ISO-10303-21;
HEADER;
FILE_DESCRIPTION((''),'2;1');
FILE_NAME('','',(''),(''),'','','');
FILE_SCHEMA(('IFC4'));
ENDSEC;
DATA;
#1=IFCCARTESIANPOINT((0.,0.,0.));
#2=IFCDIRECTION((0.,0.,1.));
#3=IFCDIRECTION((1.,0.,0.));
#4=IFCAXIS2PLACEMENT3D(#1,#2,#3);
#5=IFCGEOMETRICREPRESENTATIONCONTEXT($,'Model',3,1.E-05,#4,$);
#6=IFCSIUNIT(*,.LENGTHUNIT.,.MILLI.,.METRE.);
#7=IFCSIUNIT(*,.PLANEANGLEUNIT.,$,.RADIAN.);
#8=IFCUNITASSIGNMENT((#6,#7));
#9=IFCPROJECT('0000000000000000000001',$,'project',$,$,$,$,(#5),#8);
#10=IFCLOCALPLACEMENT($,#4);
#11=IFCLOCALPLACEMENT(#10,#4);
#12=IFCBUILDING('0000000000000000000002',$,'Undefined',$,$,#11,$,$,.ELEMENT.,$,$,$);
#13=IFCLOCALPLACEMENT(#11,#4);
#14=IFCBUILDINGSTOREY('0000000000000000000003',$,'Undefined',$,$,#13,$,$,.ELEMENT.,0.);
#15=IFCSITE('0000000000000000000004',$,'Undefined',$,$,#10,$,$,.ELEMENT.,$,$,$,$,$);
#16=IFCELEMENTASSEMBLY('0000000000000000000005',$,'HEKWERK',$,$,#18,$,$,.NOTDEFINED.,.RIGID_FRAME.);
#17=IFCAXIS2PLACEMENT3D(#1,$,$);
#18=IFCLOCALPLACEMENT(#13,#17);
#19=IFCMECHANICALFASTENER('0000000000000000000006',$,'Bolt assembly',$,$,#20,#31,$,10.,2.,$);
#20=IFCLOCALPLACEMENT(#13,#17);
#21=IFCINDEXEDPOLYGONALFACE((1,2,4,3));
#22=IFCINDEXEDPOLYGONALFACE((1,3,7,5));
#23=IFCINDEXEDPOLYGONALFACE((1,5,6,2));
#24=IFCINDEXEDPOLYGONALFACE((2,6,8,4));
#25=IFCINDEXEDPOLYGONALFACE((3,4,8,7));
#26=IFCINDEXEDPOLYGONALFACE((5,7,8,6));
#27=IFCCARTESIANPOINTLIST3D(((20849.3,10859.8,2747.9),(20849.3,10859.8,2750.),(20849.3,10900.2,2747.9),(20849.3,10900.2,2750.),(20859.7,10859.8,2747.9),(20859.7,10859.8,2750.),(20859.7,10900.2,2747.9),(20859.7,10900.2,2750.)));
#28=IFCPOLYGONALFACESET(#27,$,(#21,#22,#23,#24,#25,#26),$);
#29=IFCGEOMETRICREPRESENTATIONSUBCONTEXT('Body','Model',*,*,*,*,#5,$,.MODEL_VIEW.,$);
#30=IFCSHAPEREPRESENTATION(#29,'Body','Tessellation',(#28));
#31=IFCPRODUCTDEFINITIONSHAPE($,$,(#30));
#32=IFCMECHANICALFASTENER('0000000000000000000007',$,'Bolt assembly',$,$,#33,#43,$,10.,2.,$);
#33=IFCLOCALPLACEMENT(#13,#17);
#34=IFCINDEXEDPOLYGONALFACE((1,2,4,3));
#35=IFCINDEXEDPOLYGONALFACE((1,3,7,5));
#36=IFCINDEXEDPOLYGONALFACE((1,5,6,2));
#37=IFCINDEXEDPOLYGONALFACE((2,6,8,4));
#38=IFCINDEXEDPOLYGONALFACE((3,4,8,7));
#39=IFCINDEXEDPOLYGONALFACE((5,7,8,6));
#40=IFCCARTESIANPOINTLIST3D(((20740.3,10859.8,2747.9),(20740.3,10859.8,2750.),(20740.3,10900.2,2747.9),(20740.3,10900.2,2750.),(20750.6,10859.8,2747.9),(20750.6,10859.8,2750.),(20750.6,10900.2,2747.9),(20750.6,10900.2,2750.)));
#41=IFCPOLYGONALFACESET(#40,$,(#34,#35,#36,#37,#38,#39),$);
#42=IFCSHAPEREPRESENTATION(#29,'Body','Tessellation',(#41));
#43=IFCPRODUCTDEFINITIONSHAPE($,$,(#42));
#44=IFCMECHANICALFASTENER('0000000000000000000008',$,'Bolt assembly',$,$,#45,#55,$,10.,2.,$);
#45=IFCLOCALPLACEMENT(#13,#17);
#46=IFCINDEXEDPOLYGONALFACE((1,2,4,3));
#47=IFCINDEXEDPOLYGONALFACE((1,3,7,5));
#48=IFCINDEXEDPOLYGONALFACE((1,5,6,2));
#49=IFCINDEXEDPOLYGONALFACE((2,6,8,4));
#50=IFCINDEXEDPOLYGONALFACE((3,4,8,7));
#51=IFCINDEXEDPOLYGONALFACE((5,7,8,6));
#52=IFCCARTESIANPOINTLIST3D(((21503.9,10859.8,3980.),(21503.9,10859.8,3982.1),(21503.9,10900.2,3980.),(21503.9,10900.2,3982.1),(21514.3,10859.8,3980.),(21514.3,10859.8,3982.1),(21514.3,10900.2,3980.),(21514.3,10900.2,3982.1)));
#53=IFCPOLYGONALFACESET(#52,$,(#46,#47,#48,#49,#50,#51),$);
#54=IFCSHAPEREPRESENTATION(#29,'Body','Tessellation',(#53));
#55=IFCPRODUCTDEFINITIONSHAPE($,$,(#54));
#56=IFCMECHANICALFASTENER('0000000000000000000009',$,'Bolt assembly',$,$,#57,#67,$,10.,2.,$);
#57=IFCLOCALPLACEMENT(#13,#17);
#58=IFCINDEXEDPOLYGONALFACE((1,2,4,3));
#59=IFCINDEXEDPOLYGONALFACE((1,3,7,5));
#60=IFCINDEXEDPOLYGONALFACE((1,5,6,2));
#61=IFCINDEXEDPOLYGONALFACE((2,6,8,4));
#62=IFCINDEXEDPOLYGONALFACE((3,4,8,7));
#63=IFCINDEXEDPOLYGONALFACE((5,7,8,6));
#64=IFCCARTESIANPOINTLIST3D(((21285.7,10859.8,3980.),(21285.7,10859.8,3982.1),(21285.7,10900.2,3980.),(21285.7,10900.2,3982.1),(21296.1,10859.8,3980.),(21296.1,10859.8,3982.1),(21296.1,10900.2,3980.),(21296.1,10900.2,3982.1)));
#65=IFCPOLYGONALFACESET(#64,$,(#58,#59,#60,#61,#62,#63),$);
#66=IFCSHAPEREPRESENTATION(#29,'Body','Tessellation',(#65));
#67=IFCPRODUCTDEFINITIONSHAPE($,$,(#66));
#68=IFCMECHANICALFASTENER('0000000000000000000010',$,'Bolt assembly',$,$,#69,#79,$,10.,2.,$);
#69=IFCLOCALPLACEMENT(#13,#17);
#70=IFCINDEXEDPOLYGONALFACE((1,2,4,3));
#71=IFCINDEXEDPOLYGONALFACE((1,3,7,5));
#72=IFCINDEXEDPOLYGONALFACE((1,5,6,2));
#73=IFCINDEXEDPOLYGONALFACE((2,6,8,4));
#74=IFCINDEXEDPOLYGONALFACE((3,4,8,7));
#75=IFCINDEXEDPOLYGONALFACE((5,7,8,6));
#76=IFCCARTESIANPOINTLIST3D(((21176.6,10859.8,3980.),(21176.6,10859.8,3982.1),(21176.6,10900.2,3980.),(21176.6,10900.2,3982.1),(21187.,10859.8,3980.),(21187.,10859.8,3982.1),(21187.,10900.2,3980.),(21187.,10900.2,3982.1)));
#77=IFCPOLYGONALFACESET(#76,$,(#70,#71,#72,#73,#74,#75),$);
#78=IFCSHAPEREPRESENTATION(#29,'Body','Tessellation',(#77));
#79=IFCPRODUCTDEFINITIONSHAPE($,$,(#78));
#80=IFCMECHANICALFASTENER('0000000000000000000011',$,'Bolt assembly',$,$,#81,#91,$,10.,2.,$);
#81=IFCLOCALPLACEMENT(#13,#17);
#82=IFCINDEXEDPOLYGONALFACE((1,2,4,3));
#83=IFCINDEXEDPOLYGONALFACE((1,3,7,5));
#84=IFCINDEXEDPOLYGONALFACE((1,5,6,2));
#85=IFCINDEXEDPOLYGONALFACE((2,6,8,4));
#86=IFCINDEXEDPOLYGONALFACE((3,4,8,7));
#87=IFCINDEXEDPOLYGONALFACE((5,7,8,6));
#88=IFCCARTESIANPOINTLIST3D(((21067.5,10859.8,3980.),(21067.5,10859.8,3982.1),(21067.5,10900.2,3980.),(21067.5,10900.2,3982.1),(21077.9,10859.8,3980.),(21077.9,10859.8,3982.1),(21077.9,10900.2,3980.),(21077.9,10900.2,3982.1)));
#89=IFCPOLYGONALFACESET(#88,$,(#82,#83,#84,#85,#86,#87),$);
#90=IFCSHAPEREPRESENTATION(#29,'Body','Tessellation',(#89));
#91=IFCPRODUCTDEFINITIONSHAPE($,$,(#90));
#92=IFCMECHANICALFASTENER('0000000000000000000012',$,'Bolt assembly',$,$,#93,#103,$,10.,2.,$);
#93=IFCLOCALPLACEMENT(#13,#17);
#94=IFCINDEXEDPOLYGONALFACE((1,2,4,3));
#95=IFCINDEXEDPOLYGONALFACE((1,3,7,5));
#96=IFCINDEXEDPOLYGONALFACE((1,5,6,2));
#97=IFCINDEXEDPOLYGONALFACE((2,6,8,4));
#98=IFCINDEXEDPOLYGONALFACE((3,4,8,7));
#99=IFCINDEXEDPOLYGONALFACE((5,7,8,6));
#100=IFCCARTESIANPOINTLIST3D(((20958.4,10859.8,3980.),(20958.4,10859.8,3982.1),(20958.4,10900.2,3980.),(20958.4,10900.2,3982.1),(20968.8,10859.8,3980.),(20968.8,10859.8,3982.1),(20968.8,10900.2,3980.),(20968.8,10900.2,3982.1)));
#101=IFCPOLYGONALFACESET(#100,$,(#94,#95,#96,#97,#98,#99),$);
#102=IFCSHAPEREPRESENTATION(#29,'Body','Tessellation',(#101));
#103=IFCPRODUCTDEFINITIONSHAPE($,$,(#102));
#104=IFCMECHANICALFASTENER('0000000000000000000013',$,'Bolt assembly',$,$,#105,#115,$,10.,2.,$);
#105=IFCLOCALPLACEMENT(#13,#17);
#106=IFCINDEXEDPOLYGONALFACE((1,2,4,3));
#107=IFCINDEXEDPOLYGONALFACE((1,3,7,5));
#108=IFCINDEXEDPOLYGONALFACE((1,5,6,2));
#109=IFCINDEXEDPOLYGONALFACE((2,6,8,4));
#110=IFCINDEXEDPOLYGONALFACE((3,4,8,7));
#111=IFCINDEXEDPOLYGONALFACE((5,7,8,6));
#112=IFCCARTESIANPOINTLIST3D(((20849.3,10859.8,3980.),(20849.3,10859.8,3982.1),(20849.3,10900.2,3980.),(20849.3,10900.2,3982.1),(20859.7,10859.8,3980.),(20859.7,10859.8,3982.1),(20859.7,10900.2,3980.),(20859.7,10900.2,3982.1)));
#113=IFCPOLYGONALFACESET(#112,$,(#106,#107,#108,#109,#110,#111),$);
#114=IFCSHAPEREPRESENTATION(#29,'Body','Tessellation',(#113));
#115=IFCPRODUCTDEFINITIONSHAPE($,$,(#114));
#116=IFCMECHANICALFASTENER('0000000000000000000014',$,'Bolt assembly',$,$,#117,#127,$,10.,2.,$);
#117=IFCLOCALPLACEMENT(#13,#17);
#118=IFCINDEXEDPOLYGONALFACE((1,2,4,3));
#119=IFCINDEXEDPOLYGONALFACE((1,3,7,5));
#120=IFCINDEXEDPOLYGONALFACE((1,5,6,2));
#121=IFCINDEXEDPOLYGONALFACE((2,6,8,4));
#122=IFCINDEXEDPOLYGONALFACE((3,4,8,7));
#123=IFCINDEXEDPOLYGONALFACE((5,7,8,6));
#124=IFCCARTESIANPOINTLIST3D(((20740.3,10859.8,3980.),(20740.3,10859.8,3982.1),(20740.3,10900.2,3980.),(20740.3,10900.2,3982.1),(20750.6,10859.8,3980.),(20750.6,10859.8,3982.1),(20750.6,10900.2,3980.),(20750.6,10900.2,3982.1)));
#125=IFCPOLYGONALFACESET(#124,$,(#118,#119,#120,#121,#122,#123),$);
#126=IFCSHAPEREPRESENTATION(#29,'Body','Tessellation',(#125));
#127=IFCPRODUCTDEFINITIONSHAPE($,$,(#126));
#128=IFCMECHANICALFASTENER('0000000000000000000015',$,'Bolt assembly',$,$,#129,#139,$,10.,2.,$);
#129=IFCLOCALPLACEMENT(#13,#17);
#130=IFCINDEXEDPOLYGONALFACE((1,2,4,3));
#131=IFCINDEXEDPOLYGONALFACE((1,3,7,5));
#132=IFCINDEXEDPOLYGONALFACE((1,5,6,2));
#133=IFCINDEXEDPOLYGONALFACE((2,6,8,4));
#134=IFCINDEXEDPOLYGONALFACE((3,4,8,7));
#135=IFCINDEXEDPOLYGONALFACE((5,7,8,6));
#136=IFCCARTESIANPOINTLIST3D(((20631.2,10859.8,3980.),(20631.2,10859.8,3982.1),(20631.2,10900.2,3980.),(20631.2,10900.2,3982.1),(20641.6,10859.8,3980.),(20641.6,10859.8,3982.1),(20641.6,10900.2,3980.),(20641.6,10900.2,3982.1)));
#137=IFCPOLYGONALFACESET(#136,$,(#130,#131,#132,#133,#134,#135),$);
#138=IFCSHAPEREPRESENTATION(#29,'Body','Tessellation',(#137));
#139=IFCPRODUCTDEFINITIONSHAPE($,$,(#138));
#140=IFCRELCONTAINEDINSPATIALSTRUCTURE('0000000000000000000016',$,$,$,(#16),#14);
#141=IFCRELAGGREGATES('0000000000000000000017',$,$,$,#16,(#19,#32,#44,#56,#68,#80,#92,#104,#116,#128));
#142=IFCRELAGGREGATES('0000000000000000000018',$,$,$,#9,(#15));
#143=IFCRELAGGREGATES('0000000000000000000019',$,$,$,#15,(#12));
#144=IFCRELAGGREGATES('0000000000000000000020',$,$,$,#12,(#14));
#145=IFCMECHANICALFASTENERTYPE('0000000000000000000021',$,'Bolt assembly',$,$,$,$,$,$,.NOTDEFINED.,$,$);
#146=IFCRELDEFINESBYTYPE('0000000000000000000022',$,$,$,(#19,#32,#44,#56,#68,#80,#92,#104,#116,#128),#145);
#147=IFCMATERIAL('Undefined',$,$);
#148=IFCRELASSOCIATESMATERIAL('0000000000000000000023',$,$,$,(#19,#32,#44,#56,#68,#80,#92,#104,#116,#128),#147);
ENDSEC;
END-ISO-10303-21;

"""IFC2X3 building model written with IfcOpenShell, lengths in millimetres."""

from ifc_helpers import new_model, si_unit, frame, origin_with_axes, place, context, subcontext, project, spatial, polyline, segment, composite_curve, outline, extrude, source, transform, mapped, material, type_object, element, aggregate, save


model = new_model("IFC2X3")

# Units and contexts
model_context = context("Model", 3, precision=1e-05, world=origin_with_axes())
body_context = subcontext(model_context, "Body", "Model", "MODEL_VIEW")
ifc_project = project(units=[si_unit("LENGTHUNIT", "METRE", prefix="MILLI"), si_unit("PLANEANGLEUNIT", "RADIAN")], contexts=[model_context])

# Site, building, storey
site_placement = place(None, origin_with_axes())
site = spatial("IfcSite", under=ifc_project, at=site_placement, Name="Undefined", CompositionType="ELEMENT")
building_placement = place(site_placement, origin_with_axes())
building = spatial("IfcBuilding", under=site, at=building_placement, Name="Undefined", CompositionType="ELEMENT")
storey_placement = place(building_placement, origin_with_axes())
storey = spatial("IfcBuildingStorey", under=building, at=storey_placement, Name="Undefined", CompositionType="ELEMENT", Elevation=0.0)

# Element assembly
assembly_1_placement = place(storey_placement, origin_with_axes())
assembly_1 = element("IfcElementAssembly", 1, at=assembly_1_placement, inside=storey, Name="HEKWERK", AssemblyPlace="NOTDEFINED", PredefinedType="RIGID_FRAME")

# Mechanical fasteners
ifc_material_1 = material(Name="Undefined")
mechanical_fastener_type = type_object("IfcMechanicalFastenerType", Name="Bolt assembly")
shared_shape_1 = source(origin_with_axes(), body_context, "Body", "SweptSolid", [
    extrude(outline(composite_curve([segment(polyline([(-20.2, 5.2), (20.2, 5.2)]), True, "CONTINUOUS"), segment(polyline([(20.2, 5.2), (20.2, -5.2)]), True, "CONTINUOUS"), segment(polyline([(20.2, -5.2), (-20.2, -5.2)]), True, "CONTINUOUS"), segment(polyline([(-20.2, -5.2), (-20.2, 5.2)]), True, "CONTINUOUS")], self_intersect=False)), frame((0.0, -1.0, 0.0), z_axis=(0.0, 1.0, 0.0), x_axis=(1.0, 0.0, 0.0)), (0.0, 0.0, 1.0), 2.1),
])
mechanical_fastener_1_placement = place(assembly_1_placement, frame((20854.5, 10880.0, 2749.0), z_axis=(1.0, 0.0, 0.0), x_axis=(0.0, -1.0, 0.0)))
mechanical_fastener_1 = element("IfcMechanicalFastener", 2, at=mechanical_fastener_1_placement, type_object=mechanical_fastener_type, material=ifc_material_1, Name="Bolt assembly", NominalDiameter=10.0, NominalLength=2.0, context=body_context, shape_type="MappedRepresentation", body=[
    mapped(shared_shape_1, transform((0.0, 0.0, 0.0))),
])
shared_shape_2 = source(origin_with_axes(), body_context, "Body", "SweptSolid", [
    extrude(outline(composite_curve([segment(polyline([(-20.2, 5.2), (20.2, 5.2)]), True, "CONTINUOUS"), segment(polyline([(20.2, 5.2), (20.2, -5.2)]), True, "CONTINUOUS"), segment(polyline([(20.2, -5.2), (-20.2, -5.2)]), True, "CONTINUOUS"), segment(polyline([(-20.2, -5.2), (-20.2, 5.2)]), True, "CONTINUOUS")], self_intersect=False)), frame((0.0, -1.0, 0.0), z_axis=(0.0, 1.0, 0.0), x_axis=(1.0, 0.0, 0.0)), (0.0, 0.0, 1.0), 2.1),
])
mechanical_fastener_2_placement = place(assembly_1_placement, frame((20745.4, 10880.0, 2749.0), z_axis=(1.0, 0.0, 0.0), x_axis=(0.0, -1.0, 0.0)))
mechanical_fastener_2 = element("IfcMechanicalFastener", 3, at=mechanical_fastener_2_placement, type_object=mechanical_fastener_type, material=ifc_material_1, Name="Bolt assembly", NominalDiameter=10.0, NominalLength=2.0, context=body_context, shape_type="MappedRepresentation", body=[
    mapped(shared_shape_2, transform((0.0, 0.0, 0.0))),
])
shared_shape_3 = source(origin_with_axes(), body_context, "Body", "SweptSolid", [
    extrude(outline(composite_curve([segment(polyline([(-20.2, 5.2), (20.2, 5.2)]), True, "CONTINUOUS"), segment(polyline([(20.2, 5.2), (20.2, -5.2)]), True, "CONTINUOUS"), segment(polyline([(20.2, -5.2), (-20.2, -5.2)]), True, "CONTINUOUS"), segment(polyline([(-20.2, -5.2), (-20.2, 5.2)]), True, "CONTINUOUS")], self_intersect=False)), frame((0.0, -1.0, 0.0), z_axis=(0.0, 1.0, 0.0), x_axis=(1.0, 0.0, 0.0)), (0.0, 0.0, 1.0), 2.1),
])
mechanical_fastener_3_placement = place(assembly_1_placement, frame((21509.1, 10880.0, 3981.0), z_axis=(-1.0, 0.0, 0.0), x_axis=(0.0, -1.0, 0.0)))
mechanical_fastener_3 = element("IfcMechanicalFastener", 4, at=mechanical_fastener_3_placement, type_object=mechanical_fastener_type, material=ifc_material_1, Name="Bolt assembly", NominalDiameter=10.0, NominalLength=2.0, context=body_context, shape_type="MappedRepresentation", body=[
    mapped(shared_shape_3, transform((0.0, 0.0, 0.0))),
])
shared_shape_4 = source(origin_with_axes(), body_context, "Body", "SweptSolid", [
    extrude(outline(composite_curve([segment(polyline([(-20.2, 5.2), (20.2, 5.2)]), True, "CONTINUOUS"), segment(polyline([(20.2, 5.2), (20.2, -5.2)]), True, "CONTINUOUS"), segment(polyline([(20.2, -5.2), (-20.2, -5.2)]), True, "CONTINUOUS"), segment(polyline([(-20.2, -5.2), (-20.2, 5.2)]), True, "CONTINUOUS")], self_intersect=False)), frame((0.0, -1.0, 0.0), z_axis=(0.0, 1.0, 0.0), x_axis=(1.0, 0.0, 0.0)), (0.0, 0.0, 1.0), 2.1),
])
mechanical_fastener_4_placement = place(assembly_1_placement, frame((21290.9, 10880.0, 3981.0), z_axis=(-1.0, 0.0, 0.0), x_axis=(0.0, -1.0, 0.0)))
mechanical_fastener_4 = element("IfcMechanicalFastener", 5, at=mechanical_fastener_4_placement, type_object=mechanical_fastener_type, material=ifc_material_1, Name="Bolt assembly", NominalDiameter=10.0, NominalLength=2.0, context=body_context, shape_type="MappedRepresentation", body=[
    mapped(shared_shape_4, transform((0.0, 0.0, 0.0))),
])
shared_shape_5 = source(origin_with_axes(), body_context, "Body", "SweptSolid", [
    extrude(outline(composite_curve([segment(polyline([(-20.2, 5.2), (20.2, 5.2)]), True, "CONTINUOUS"), segment(polyline([(20.2, 5.2), (20.2, -5.2)]), True, "CONTINUOUS"), segment(polyline([(20.2, -5.2), (-20.2, -5.2)]), True, "CONTINUOUS"), segment(polyline([(-20.2, -5.2), (-20.2, 5.2)]), True, "CONTINUOUS")], self_intersect=False)), frame((0.0, -1.0, 0.0), z_axis=(0.0, 1.0, 0.0), x_axis=(1.0, 0.0, 0.0)), (0.0, 0.0, 1.0), 2.1),
])
mechanical_fastener_5_placement = place(assembly_1_placement, frame((21181.8, 10880.0, 3981.0), z_axis=(-1.0, 0.0, 0.0), x_axis=(0.0, -1.0, 0.0)))
mechanical_fastener_5 = element("IfcMechanicalFastener", 6, at=mechanical_fastener_5_placement, type_object=mechanical_fastener_type, material=ifc_material_1, Name="Bolt assembly", NominalDiameter=10.0, NominalLength=2.0, context=body_context, shape_type="MappedRepresentation", body=[
    mapped(shared_shape_5, transform((0.0, 0.0, 0.0))),
])
shared_shape_6 = source(origin_with_axes(), body_context, "Body", "SweptSolid", [
    extrude(outline(composite_curve([segment(polyline([(-20.2, 5.2), (20.2, 5.2)]), True, "CONTINUOUS"), segment(polyline([(20.2, 5.2), (20.2, -5.2)]), True, "CONTINUOUS"), segment(polyline([(20.2, -5.2), (-20.2, -5.2)]), True, "CONTINUOUS"), segment(polyline([(-20.2, -5.2), (-20.2, 5.2)]), True, "CONTINUOUS")], self_intersect=False)), frame((0.0, -1.0, 0.0), z_axis=(0.0, 1.0, 0.0), x_axis=(1.0, 0.0, 0.0)), (0.0, 0.0, 1.0), 2.1),
])
mechanical_fastener_6_placement = place(assembly_1_placement, frame((21072.7, 10880.0, 3981.0), z_axis=(-1.0, 0.0, 0.0), x_axis=(0.0, -1.0, 0.0)))
mechanical_fastener_6 = element("IfcMechanicalFastener", 7, at=mechanical_fastener_6_placement, type_object=mechanical_fastener_type, material=ifc_material_1, Name="Bolt assembly", NominalDiameter=10.0, NominalLength=2.0, context=body_context, shape_type="MappedRepresentation", body=[
    mapped(shared_shape_6, transform((0.0, 0.0, 0.0))),
])
shared_shape_7 = source(origin_with_axes(), body_context, "Body", "SweptSolid", [
    extrude(outline(composite_curve([segment(polyline([(-20.2, 5.2), (20.2, 5.2)]), True, "CONTINUOUS"), segment(polyline([(20.2, 5.2), (20.2, -5.2)]), True, "CONTINUOUS"), segment(polyline([(20.2, -5.2), (-20.2, -5.2)]), True, "CONTINUOUS"), segment(polyline([(-20.2, -5.2), (-20.2, 5.2)]), True, "CONTINUOUS")], self_intersect=False)), frame((0.0, -1.0, 0.0), z_axis=(0.0, 1.0, 0.0), x_axis=(1.0, 0.0, 0.0)), (0.0, 0.0, 1.0), 2.1),
])
mechanical_fastener_7_placement = place(assembly_1_placement, frame((20963.6, 10880.0, 3981.0), z_axis=(-1.0, 0.0, 0.0), x_axis=(0.0, -1.0, 0.0)))
mechanical_fastener_7 = element("IfcMechanicalFastener", 8, at=mechanical_fastener_7_placement, type_object=mechanical_fastener_type, material=ifc_material_1, Name="Bolt assembly", NominalDiameter=10.0, NominalLength=2.0, context=body_context, shape_type="MappedRepresentation", body=[
    mapped(shared_shape_7, transform((0.0, 0.0, 0.0))),
])
shared_shape_8 = source(origin_with_axes(), body_context, "Body", "SweptSolid", [
    extrude(outline(composite_curve([segment(polyline([(-20.2, 5.2), (20.2, 5.2)]), True, "CONTINUOUS"), segment(polyline([(20.2, 5.2), (20.2, -5.2)]), True, "CONTINUOUS"), segment(polyline([(20.2, -5.2), (-20.2, -5.2)]), True, "CONTINUOUS"), segment(polyline([(-20.2, -5.2), (-20.2, 5.2)]), True, "CONTINUOUS")], self_intersect=False)), frame((0.0, -1.0, 0.0), z_axis=(0.0, 1.0, 0.0), x_axis=(1.0, 0.0, 0.0)), (0.0, 0.0, 1.0), 2.1),
])
mechanical_fastener_8_placement = place(assembly_1_placement, frame((20854.5, 10880.0, 3981.0), z_axis=(-1.0, 0.0, 0.0), x_axis=(0.0, -1.0, 0.0)))
mechanical_fastener_8 = element("IfcMechanicalFastener", 9, at=mechanical_fastener_8_placement, type_object=mechanical_fastener_type, material=ifc_material_1, Name="Bolt assembly", NominalDiameter=10.0, NominalLength=2.0, context=body_context, shape_type="MappedRepresentation", body=[
    mapped(shared_shape_8, transform((0.0, 0.0, 0.0))),
])
shared_shape_9 = source(origin_with_axes(), body_context, "Body", "SweptSolid", [
    extrude(outline(composite_curve([segment(polyline([(-20.2, 5.2), (20.2, 5.2)]), True, "CONTINUOUS"), segment(polyline([(20.2, 5.2), (20.2, -5.2)]), True, "CONTINUOUS"), segment(polyline([(20.2, -5.2), (-20.2, -5.2)]), True, "CONTINUOUS"), segment(polyline([(-20.2, -5.2), (-20.2, 5.2)]), True, "CONTINUOUS")], self_intersect=False)), frame((0.0, -1.0, 0.0), z_axis=(0.0, 1.0, 0.0), x_axis=(1.0, 0.0, 0.0)), (0.0, 0.0, 1.0), 2.1),
])
mechanical_fastener_9_placement = place(assembly_1_placement, frame((20745.4, 10880.0, 3981.0), z_axis=(-1.0, 0.0, 0.0), x_axis=(0.0, -1.0, 0.0)))
mechanical_fastener_9 = element("IfcMechanicalFastener", 10, at=mechanical_fastener_9_placement, type_object=mechanical_fastener_type, material=ifc_material_1, Name="Bolt assembly", NominalDiameter=10.0, NominalLength=2.0, context=body_context, shape_type="MappedRepresentation", body=[
    mapped(shared_shape_9, transform((0.0, 0.0, 0.0))),
])
shared_shape_10 = source(origin_with_axes(), body_context, "Body", "SweptSolid", [
    extrude(outline(composite_curve([segment(polyline([(-20.2, 5.2), (20.2, 5.2)]), True, "CONTINUOUS"), segment(polyline([(20.2, 5.2), (20.2, -5.2)]), True, "CONTINUOUS"), segment(polyline([(20.2, -5.2), (-20.2, -5.2)]), True, "CONTINUOUS"), segment(polyline([(-20.2, -5.2), (-20.2, 5.2)]), True, "CONTINUOUS")], self_intersect=False)), frame((0.0, -1.0, 0.0), z_axis=(0.0, 1.0, 0.0), x_axis=(1.0, 0.0, 0.0)), (0.0, 0.0, 1.0), 2.1),
])
mechanical_fastener_10_placement = place(assembly_1_placement, frame((20636.4, 10880.0, 3981.0), z_axis=(-1.0, 0.0, 0.0), x_axis=(0.0, -1.0, 0.0)))
mechanical_fastener_10 = element("IfcMechanicalFastener", 11, at=mechanical_fastener_10_placement, type_object=mechanical_fastener_type, material=ifc_material_1, Name="Bolt assembly", NominalDiameter=10.0, NominalLength=2.0, context=body_context, shape_type="MappedRepresentation", body=[
    mapped(shared_shape_10, transform((0.0, 0.0, 0.0))),
])
aggregate(assembly_1, [mechanical_fastener_1, mechanical_fastener_2, mechanical_fastener_3, mechanical_fastener_4, mechanical_fastener_5, mechanical_fastener_6, mechanical_fastener_7, mechanical_fastener_8, mechanical_fastener_9, mechanical_fastener_10])

save(model, "model.ifc")
